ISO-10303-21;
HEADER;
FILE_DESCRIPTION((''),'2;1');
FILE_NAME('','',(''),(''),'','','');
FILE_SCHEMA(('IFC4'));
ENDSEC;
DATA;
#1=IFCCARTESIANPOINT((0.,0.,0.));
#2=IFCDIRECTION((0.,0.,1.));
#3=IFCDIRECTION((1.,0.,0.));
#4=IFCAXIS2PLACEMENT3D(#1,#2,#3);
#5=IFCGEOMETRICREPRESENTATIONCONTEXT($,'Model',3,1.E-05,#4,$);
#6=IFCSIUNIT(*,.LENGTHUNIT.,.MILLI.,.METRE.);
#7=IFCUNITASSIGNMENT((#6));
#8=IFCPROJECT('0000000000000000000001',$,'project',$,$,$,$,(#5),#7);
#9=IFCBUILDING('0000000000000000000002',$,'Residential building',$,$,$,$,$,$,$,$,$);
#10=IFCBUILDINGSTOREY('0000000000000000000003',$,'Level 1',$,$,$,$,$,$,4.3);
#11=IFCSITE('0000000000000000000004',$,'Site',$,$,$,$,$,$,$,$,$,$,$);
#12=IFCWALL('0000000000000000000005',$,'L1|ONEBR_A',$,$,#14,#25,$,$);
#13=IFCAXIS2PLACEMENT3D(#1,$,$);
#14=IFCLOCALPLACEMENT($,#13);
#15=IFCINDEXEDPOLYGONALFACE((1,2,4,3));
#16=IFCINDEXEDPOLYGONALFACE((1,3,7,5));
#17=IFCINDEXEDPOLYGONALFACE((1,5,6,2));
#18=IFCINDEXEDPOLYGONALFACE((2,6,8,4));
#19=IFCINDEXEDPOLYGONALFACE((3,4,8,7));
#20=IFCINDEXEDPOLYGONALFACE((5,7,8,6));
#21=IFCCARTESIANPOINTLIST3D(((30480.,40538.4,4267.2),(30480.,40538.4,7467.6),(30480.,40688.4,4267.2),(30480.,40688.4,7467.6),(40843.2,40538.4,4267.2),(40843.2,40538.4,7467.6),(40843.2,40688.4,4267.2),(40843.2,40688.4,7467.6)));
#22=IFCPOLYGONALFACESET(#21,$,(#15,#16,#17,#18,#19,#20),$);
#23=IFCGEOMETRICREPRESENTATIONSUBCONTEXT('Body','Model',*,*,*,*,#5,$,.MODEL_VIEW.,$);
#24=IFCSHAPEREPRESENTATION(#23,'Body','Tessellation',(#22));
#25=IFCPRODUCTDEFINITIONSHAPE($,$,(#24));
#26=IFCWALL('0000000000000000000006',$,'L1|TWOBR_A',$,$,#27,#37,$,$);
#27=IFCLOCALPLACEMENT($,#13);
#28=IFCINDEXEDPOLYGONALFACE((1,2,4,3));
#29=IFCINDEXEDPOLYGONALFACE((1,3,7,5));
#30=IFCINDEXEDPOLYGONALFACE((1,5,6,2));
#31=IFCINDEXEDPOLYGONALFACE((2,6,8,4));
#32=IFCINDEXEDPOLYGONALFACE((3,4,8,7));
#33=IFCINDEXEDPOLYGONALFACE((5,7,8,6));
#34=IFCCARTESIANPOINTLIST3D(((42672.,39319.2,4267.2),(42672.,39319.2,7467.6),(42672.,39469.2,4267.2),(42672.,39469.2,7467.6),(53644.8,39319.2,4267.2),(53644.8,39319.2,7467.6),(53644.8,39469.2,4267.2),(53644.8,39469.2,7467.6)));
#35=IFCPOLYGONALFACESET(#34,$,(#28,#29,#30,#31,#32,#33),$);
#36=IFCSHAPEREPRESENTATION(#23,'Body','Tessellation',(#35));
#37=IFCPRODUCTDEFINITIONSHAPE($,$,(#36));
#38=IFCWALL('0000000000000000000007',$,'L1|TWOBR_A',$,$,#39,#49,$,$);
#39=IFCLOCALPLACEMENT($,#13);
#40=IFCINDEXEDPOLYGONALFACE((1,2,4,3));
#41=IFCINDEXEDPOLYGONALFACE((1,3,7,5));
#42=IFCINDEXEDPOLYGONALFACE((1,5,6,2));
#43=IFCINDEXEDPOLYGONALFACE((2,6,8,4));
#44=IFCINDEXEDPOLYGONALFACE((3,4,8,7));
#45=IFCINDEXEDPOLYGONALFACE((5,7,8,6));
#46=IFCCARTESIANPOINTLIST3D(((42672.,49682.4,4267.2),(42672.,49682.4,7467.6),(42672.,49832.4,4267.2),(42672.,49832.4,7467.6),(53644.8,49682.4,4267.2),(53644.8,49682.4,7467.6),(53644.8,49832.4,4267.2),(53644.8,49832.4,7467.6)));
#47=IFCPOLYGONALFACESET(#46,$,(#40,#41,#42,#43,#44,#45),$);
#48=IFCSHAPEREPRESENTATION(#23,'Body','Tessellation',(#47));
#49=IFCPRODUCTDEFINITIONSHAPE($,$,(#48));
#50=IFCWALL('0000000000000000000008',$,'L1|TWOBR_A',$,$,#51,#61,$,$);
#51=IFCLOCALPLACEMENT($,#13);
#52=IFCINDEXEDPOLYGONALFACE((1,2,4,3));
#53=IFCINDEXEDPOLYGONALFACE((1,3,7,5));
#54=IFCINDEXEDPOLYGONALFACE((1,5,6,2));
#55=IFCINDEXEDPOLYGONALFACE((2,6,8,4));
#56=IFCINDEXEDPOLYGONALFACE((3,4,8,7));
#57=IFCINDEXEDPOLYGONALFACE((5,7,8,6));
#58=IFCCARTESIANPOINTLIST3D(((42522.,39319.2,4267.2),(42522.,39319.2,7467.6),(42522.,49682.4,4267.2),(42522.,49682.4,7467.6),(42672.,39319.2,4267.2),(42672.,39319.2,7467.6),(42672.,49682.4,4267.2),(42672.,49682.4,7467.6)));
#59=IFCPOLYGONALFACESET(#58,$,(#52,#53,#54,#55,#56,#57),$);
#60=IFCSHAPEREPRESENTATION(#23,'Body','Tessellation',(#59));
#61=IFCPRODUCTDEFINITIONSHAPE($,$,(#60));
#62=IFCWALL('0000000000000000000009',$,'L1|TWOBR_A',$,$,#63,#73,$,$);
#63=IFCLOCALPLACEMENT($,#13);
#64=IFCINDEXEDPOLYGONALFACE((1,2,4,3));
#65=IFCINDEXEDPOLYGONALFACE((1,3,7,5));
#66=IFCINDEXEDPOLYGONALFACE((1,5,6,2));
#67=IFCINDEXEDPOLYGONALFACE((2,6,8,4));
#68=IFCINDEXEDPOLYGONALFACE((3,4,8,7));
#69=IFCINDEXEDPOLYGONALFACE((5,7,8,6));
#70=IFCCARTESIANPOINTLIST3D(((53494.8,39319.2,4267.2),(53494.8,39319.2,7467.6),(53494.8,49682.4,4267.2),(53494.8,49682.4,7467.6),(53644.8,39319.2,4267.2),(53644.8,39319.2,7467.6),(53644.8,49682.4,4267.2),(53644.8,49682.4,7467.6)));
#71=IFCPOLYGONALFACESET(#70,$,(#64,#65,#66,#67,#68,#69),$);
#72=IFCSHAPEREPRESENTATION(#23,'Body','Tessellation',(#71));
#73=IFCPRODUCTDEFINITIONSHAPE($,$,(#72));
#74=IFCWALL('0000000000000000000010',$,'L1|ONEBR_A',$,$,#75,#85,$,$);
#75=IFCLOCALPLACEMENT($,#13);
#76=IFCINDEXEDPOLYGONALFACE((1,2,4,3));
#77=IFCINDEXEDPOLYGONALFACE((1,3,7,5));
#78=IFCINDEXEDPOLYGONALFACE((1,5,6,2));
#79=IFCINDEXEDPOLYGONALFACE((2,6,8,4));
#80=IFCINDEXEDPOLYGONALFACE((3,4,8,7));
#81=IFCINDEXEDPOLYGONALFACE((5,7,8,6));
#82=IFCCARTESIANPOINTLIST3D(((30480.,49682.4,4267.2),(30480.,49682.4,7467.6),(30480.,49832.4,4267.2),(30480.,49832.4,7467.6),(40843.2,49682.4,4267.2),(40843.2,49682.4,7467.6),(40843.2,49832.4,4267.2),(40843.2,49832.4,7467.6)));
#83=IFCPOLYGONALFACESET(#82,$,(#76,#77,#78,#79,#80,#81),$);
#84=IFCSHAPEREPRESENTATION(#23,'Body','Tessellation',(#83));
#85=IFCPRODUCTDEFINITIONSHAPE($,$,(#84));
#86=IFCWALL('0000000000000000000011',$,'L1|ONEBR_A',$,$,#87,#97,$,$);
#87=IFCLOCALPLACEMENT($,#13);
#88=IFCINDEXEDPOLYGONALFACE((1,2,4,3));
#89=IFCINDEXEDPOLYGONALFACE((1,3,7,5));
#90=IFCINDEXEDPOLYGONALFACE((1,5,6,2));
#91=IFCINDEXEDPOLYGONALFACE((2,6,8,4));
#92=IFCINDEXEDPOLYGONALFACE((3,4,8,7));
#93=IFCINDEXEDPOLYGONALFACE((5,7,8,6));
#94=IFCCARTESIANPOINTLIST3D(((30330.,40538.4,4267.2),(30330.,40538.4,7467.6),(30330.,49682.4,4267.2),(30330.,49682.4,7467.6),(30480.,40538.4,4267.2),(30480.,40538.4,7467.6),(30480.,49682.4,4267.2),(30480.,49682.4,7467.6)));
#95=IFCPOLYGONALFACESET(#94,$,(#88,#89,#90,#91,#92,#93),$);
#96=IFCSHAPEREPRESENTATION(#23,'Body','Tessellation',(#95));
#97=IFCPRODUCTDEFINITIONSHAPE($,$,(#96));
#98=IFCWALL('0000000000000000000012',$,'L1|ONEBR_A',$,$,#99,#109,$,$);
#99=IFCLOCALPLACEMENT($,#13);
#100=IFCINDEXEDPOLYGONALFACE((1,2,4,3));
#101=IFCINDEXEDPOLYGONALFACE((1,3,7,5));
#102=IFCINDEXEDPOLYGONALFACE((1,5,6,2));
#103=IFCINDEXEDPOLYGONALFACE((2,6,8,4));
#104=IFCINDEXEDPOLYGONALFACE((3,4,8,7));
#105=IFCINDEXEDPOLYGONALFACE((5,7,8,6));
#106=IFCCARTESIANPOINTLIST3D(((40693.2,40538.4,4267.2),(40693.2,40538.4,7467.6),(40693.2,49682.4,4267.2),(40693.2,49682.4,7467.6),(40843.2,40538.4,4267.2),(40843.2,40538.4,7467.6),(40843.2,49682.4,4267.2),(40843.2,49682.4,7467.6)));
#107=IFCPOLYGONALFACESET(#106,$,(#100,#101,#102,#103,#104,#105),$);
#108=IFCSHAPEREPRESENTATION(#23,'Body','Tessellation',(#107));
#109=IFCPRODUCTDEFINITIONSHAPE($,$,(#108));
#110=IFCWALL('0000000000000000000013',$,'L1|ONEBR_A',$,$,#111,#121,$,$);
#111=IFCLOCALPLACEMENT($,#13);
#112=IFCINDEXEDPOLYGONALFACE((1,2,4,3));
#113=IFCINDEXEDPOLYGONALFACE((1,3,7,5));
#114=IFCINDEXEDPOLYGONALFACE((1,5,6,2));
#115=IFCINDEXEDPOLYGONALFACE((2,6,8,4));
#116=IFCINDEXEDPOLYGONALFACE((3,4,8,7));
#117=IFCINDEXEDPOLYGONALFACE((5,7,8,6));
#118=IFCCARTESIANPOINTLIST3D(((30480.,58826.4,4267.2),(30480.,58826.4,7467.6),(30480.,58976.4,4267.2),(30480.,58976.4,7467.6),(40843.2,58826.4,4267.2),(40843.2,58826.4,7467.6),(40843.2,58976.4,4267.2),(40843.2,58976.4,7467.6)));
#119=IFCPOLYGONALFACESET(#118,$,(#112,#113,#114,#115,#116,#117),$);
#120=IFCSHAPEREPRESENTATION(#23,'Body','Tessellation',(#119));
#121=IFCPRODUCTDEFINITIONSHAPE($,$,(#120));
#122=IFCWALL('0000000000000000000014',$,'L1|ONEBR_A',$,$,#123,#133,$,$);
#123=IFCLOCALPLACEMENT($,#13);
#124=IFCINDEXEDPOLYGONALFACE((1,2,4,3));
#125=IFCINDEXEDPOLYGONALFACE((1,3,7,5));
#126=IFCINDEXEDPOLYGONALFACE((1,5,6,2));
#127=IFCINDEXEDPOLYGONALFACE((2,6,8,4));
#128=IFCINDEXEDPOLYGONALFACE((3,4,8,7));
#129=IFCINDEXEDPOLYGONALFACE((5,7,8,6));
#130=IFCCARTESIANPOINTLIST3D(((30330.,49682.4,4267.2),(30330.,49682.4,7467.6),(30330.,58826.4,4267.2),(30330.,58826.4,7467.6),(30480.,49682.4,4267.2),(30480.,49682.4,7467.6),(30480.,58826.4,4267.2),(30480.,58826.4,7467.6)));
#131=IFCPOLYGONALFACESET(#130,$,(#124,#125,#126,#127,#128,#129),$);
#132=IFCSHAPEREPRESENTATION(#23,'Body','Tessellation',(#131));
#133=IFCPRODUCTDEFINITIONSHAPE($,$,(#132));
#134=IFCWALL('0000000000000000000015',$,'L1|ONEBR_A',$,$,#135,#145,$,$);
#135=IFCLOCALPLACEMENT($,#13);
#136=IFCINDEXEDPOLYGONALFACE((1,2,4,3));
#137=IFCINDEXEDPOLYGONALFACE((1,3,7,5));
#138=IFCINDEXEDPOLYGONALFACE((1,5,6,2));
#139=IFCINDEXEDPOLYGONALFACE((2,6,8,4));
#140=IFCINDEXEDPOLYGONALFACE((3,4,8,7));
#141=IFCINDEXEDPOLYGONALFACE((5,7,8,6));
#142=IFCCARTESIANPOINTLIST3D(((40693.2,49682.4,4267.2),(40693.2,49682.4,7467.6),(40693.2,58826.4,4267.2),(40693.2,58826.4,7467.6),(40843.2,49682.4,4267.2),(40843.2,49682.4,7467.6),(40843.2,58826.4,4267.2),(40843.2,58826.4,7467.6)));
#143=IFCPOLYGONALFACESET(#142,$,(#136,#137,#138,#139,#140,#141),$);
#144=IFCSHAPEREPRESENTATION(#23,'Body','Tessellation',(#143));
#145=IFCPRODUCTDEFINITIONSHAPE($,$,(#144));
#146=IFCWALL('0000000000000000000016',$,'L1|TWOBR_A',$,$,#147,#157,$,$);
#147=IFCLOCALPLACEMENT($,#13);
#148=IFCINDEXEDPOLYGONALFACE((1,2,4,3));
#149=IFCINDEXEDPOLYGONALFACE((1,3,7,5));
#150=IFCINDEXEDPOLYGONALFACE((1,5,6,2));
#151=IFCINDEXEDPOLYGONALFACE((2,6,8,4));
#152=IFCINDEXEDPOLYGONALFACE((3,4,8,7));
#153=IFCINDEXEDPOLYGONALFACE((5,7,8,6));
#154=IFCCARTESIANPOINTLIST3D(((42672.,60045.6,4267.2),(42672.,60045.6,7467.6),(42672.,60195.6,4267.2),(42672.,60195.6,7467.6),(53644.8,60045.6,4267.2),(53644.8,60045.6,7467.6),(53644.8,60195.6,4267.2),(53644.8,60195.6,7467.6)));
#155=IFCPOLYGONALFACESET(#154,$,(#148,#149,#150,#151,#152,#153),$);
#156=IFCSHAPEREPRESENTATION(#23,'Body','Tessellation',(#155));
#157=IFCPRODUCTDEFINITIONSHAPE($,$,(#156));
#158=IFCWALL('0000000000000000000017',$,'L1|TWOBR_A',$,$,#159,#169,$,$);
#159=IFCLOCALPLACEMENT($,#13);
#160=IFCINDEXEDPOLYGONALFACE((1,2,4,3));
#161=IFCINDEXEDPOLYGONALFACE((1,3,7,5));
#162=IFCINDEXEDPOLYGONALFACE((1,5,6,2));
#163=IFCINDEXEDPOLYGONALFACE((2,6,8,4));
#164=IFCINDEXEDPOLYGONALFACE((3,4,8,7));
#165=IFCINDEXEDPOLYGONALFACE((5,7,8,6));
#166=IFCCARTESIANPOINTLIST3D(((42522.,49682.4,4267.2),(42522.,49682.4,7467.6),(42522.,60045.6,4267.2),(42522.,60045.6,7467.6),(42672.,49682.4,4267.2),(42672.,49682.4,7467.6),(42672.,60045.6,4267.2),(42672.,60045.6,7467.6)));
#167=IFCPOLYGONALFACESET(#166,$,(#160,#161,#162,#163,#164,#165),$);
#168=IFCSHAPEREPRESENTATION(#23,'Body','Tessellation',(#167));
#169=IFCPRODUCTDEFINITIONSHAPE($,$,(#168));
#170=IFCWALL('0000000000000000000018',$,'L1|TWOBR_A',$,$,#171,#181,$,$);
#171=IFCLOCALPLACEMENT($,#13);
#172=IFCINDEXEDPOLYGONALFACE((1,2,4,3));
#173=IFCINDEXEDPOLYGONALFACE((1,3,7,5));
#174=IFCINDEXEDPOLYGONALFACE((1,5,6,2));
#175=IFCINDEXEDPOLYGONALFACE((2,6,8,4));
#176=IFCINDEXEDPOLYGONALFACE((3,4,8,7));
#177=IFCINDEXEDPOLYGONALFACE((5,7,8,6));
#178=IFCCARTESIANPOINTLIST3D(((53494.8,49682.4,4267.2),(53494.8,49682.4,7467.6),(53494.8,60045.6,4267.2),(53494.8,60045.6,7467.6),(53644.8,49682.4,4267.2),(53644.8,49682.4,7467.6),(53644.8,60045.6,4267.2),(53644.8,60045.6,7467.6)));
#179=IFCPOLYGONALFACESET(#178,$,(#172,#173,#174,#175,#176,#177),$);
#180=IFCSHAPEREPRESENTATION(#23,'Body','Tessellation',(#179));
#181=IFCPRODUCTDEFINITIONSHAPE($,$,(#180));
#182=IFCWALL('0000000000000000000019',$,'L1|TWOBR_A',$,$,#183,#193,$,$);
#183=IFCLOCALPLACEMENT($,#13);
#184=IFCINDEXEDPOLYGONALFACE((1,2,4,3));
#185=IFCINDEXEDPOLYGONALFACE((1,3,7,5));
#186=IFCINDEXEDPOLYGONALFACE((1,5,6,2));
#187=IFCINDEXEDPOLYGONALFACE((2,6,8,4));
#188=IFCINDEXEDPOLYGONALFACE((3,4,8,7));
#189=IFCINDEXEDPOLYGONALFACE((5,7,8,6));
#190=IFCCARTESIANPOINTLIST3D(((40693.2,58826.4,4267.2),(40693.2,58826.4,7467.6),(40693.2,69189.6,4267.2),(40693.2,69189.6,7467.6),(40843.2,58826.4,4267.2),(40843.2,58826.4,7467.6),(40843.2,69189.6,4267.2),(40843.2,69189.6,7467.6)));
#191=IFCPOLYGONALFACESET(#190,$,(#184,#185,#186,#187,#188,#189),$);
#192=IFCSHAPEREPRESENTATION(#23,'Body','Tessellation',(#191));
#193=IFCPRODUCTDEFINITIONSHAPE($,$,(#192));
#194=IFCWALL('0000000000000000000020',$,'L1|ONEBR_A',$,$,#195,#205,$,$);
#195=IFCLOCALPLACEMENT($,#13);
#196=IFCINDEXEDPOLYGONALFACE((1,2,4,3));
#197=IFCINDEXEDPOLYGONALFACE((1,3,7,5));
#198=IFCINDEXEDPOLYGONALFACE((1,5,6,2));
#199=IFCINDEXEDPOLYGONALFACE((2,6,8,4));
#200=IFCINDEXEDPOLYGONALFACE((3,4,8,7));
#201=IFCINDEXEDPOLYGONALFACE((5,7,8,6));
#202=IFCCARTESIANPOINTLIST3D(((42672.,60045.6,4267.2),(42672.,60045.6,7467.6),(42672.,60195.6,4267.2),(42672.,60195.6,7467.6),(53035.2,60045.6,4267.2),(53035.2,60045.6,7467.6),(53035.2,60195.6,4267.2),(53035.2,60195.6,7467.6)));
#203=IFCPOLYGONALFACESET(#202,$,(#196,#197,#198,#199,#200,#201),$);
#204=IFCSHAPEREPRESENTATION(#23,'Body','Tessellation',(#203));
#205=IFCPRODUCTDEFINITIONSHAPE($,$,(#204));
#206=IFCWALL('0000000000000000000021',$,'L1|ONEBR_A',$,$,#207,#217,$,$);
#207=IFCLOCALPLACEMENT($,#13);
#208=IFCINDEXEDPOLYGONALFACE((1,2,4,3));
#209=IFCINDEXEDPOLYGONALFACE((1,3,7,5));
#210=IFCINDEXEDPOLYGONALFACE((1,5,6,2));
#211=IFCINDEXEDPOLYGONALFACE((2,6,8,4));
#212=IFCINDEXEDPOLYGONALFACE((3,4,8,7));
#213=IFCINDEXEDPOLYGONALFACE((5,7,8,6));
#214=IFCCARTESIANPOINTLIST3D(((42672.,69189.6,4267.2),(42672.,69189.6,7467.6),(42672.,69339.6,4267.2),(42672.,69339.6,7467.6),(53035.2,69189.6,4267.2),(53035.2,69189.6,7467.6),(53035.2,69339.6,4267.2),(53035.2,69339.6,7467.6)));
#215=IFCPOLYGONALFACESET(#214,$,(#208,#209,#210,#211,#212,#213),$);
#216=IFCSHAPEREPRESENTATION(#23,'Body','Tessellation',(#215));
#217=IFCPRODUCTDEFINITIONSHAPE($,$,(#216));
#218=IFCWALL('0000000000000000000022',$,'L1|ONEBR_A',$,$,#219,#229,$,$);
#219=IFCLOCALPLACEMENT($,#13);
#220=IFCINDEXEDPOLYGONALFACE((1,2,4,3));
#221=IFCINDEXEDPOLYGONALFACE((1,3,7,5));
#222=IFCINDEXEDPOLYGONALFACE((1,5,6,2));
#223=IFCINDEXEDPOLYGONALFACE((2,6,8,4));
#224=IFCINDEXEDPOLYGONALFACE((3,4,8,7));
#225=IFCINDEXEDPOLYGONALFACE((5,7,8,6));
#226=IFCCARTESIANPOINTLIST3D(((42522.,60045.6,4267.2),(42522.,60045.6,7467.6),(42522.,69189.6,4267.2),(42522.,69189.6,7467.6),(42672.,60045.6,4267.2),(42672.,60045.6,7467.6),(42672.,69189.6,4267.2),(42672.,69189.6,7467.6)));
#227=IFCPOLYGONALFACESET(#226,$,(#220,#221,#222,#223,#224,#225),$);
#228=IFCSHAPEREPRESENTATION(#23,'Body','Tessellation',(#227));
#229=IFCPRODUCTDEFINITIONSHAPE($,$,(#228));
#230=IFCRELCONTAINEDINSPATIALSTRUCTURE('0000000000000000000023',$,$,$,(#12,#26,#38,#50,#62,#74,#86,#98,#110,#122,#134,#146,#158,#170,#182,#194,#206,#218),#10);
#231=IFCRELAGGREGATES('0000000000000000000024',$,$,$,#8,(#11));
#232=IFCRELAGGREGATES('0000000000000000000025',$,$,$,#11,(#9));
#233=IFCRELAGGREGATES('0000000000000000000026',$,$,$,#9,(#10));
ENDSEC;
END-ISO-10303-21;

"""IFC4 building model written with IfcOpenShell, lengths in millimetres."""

from ifc_helpers import new_model, si_unit, frame, origin_with_axes, place, context, subcontext, project, spatial, indexed_curve, outline, extrude, element, save


model = new_model("IFC4")

# Units and contexts
model_context = context("Model", 3, precision=1e-05, world=origin_with_axes())
body_context = subcontext(model_context, "Body", "Model", "MODEL_VIEW")
ifc_project = project(units=[si_unit("LENGTHUNIT", "METRE", prefix="MILLI")], contexts=[model_context])

# Site, building, storey
site = spatial("IfcSite", under=ifc_project, Name="Site")
building = spatial("IfcBuilding", under=site, Name="Residential building")
storey = spatial("IfcBuildingStorey", under=building, Name="Level 1", Elevation=4.3)

# Walls
wall_placement = place(None, frame((30480.0, 40538.4, 4267.2), z_axis=(0.0, 0.0, 1.0), x_axis=(1.0, 0.0, 0.0)))
element("IfcWall", 1, at=wall_placement, inside=storey, Name="L1|ONEBR_A", context=body_context, shape_type="SweptSolid", body=[
    extrude(outline(indexed_curve([(0.0, 0.0), (0.0, 150.0), (10363.2, 150.0), (10363.2, 0.0), (0.0, 0.0)], self_intersect=False)), origin_with_axes(), (0.0, 0.0, 1.0), 3200.4),
])
for number, where, z_axis, x_axis, name in (
    (2, (42672.0, 39319.2, 4267.2), (0.0, 0.0, 1.0), (1.0, 0.0, 0.0), "L1|TWOBR_A"),
    (3, (42672.0, 49682.4, 4267.2), (0.0, 0.0, 1.0), (1.0, 0.0, 0.0), "L1|TWOBR_A"),
):
    element("IfcWall", number, at=place(None, frame(where, z_axis=z_axis, x_axis=x_axis)), inside=storey, Name=name, context=body_context, shape_type="SweptSolid", body=[
        extrude(outline(indexed_curve([(0.0, 0.0), (0.0, 150.0), (10972.8, 150.0), (10972.8, 0.0), (0.0, 0.0)], self_intersect=False)), origin_with_axes(), (0.0, 0.0, 1.0), 3200.4),
    ])
for number, where, z_axis, x_axis, name in (
    (4, (42672.0, 39319.2, 4267.2), (0.0, 0.0, 1.0), (0.0, 1.0, 0.0), "L1|TWOBR_A"),
    (5, (53644.8, 39319.2, 4267.2), (0.0, 0.0, 1.0), (0.0, 1.0, 0.0), "L1|TWOBR_A"),
    (6, (30480.0, 49682.4, 4267.2), (0.0, 0.0, 1.0), (1.0, 0.0, 0.0), "L1|ONEBR_A"),
):
    element("IfcWall", number, at=place(None, frame(where, z_axis=z_axis, x_axis=x_axis)), inside=storey, Name=name, context=body_context, shape_type="SweptSolid", body=[
        extrude(outline(indexed_curve([(0.0, 0.0), (0.0, 150.0), (10363.2, 150.0), (10363.2, 0.0), (0.0, 0.0)], self_intersect=False)), origin_with_axes(), (0.0, 0.0, 1.0), 3200.4),
    ])
for number, where, z_axis, x_axis, name in (
    (7, (30480.0, 40538.4, 4267.2), (0.0, 0.0, 1.0), (0.0, 1.0, 0.0), "L1|ONEBR_A"),
    (8, (40843.2, 40538.4, 4267.2), (0.0, 0.0, 1.0), (0.0, 1.0, 0.0), "L1|ONEBR_A"),
):
    element("IfcWall", number, at=place(None, frame(where, z_axis=z_axis, x_axis=x_axis)), inside=storey, Name=name, context=body_context, shape_type="SweptSolid", body=[
        extrude(outline(indexed_curve([(0.0, 0.0), (0.0, 150.0), (9144.0, 150.0), (9144.0, 0.0), (0.0, 0.0)], self_intersect=False)), origin_with_axes(), (0.0, 0.0, 1.0), 3200.4),
    ])
for number, where, z_axis, x_axis, name in (
    (9, (30480.0, 58826.4, 4267.2), (0.0, 0.0, 1.0), (1.0, 0.0, 0.0), "L1|ONEBR_A"),
):
    element("IfcWall", number, at=place(None, frame(where, z_axis=z_axis, x_axis=x_axis)), inside=storey, Name=name, context=body_context, shape_type="SweptSolid", body=[
        extrude(outline(indexed_curve([(0.0, 0.0), (0.0, 150.0), (10363.2, 150.0), (10363.2, 0.0), (0.0, 0.0)], self_intersect=False)), origin_with_axes(), (0.0, 0.0, 1.0), 3200.4),
    ])
for number, where, z_axis, x_axis, name in (
    (10, (30480.0, 49682.4, 4267.2), (0.0, 0.0, 1.0), (0.0, 1.0, 0.0), "L1|ONEBR_A"),
    (11, (40843.2, 49682.4, 4267.2), (0.0, 0.0, 1.0), (0.0, 1.0, 0.0), "L1|ONEBR_A"),
):
    element("IfcWall", number, at=place(None, frame(where, z_axis=z_axis, x_axis=x_axis)), inside=storey, Name=name, context=body_context, shape_type="SweptSolid", body=[
        extrude(outline(indexed_curve([(0.0, 0.0), (0.0, 150.0), (9144.0, 150.0), (9144.0, 0.0), (0.0, 0.0)], self_intersect=False)), origin_with_axes(), (0.0, 0.0, 1.0), 3200.4),
    ])
for number, where, z_axis, x_axis, name in (
    (12, (42672.0, 60045.6, 4267.2), (0.0, 0.0, 1.0), (1.0, 0.0, 0.0), "L1|TWOBR_A"),
):
    element("IfcWall", number, at=place(None, frame(where, z_axis=z_axis, x_axis=x_axis)), inside=storey, Name=name, context=body_context, shape_type="SweptSolid", body=[
        extrude(outline(indexed_curve([(0.0, 0.0), (0.0, 150.0), (10972.8, 150.0), (10972.8, 0.0), (0.0, 0.0)], self_intersect=False)), origin_with_axes(), (0.0, 0.0, 1.0), 3200.4),
    ])
for number, where, z_axis, x_axis, name in (
    (13, (42672.0, 49682.4, 4267.2), (0.0, 0.0, 1.0), (0.0, 1.0, 0.0), "L1|TWOBR_A"),
    (14, (53644.8, 49682.4, 4267.2), (0.0, 0.0, 1.0), (0.0, 1.0, 0.0), "L1|TWOBR_A"),
    (15, (40843.2, 58826.4, 4267.2), (0.0, 0.0, 1.0), (0.0, 1.0, 0.0), "L1|TWOBR_A"),
    (16, (42672.0, 60045.6, 4267.2), (0.0, 0.0, 1.0), (1.0, 0.0, 0.0), "L1|ONEBR_A"),
    (17, (42672.0, 69189.6, 4267.2), (0.0, 0.0, 1.0), (1.0, 0.0, 0.0), "L1|ONEBR_A"),
):
    element("IfcWall", number, at=place(None, frame(where, z_axis=z_axis, x_axis=x_axis)), inside=storey, Name=name, context=body_context, shape_type="SweptSolid", body=[
        extrude(outline(indexed_curve([(0.0, 0.0), (0.0, 150.0), (10363.2, 150.0), (10363.2, 0.0), (0.0, 0.0)], self_intersect=False)), origin_with_axes(), (0.0, 0.0, 1.0), 3200.4),
    ])
for number, where, z_axis, x_axis, name in (
    (18, (42672.0, 60045.6, 4267.2), (0.0, 0.0, 1.0), (0.0, 1.0, 0.0), "L1|ONEBR_A"),
):
    element("IfcWall", number, at=place(None, frame(where, z_axis=z_axis, x_axis=x_axis)), inside=storey, Name=name, context=body_context, shape_type="SweptSolid", body=[
        extrude(outline(indexed_curve([(0.0, 0.0), (0.0, 150.0), (9144.0, 150.0), (9144.0, 0.0), (0.0, 0.0)], self_intersect=False)), origin_with_axes(), (0.0, 0.0, 1.0), 3200.4),
    ])

save(model, "model.ifc")
